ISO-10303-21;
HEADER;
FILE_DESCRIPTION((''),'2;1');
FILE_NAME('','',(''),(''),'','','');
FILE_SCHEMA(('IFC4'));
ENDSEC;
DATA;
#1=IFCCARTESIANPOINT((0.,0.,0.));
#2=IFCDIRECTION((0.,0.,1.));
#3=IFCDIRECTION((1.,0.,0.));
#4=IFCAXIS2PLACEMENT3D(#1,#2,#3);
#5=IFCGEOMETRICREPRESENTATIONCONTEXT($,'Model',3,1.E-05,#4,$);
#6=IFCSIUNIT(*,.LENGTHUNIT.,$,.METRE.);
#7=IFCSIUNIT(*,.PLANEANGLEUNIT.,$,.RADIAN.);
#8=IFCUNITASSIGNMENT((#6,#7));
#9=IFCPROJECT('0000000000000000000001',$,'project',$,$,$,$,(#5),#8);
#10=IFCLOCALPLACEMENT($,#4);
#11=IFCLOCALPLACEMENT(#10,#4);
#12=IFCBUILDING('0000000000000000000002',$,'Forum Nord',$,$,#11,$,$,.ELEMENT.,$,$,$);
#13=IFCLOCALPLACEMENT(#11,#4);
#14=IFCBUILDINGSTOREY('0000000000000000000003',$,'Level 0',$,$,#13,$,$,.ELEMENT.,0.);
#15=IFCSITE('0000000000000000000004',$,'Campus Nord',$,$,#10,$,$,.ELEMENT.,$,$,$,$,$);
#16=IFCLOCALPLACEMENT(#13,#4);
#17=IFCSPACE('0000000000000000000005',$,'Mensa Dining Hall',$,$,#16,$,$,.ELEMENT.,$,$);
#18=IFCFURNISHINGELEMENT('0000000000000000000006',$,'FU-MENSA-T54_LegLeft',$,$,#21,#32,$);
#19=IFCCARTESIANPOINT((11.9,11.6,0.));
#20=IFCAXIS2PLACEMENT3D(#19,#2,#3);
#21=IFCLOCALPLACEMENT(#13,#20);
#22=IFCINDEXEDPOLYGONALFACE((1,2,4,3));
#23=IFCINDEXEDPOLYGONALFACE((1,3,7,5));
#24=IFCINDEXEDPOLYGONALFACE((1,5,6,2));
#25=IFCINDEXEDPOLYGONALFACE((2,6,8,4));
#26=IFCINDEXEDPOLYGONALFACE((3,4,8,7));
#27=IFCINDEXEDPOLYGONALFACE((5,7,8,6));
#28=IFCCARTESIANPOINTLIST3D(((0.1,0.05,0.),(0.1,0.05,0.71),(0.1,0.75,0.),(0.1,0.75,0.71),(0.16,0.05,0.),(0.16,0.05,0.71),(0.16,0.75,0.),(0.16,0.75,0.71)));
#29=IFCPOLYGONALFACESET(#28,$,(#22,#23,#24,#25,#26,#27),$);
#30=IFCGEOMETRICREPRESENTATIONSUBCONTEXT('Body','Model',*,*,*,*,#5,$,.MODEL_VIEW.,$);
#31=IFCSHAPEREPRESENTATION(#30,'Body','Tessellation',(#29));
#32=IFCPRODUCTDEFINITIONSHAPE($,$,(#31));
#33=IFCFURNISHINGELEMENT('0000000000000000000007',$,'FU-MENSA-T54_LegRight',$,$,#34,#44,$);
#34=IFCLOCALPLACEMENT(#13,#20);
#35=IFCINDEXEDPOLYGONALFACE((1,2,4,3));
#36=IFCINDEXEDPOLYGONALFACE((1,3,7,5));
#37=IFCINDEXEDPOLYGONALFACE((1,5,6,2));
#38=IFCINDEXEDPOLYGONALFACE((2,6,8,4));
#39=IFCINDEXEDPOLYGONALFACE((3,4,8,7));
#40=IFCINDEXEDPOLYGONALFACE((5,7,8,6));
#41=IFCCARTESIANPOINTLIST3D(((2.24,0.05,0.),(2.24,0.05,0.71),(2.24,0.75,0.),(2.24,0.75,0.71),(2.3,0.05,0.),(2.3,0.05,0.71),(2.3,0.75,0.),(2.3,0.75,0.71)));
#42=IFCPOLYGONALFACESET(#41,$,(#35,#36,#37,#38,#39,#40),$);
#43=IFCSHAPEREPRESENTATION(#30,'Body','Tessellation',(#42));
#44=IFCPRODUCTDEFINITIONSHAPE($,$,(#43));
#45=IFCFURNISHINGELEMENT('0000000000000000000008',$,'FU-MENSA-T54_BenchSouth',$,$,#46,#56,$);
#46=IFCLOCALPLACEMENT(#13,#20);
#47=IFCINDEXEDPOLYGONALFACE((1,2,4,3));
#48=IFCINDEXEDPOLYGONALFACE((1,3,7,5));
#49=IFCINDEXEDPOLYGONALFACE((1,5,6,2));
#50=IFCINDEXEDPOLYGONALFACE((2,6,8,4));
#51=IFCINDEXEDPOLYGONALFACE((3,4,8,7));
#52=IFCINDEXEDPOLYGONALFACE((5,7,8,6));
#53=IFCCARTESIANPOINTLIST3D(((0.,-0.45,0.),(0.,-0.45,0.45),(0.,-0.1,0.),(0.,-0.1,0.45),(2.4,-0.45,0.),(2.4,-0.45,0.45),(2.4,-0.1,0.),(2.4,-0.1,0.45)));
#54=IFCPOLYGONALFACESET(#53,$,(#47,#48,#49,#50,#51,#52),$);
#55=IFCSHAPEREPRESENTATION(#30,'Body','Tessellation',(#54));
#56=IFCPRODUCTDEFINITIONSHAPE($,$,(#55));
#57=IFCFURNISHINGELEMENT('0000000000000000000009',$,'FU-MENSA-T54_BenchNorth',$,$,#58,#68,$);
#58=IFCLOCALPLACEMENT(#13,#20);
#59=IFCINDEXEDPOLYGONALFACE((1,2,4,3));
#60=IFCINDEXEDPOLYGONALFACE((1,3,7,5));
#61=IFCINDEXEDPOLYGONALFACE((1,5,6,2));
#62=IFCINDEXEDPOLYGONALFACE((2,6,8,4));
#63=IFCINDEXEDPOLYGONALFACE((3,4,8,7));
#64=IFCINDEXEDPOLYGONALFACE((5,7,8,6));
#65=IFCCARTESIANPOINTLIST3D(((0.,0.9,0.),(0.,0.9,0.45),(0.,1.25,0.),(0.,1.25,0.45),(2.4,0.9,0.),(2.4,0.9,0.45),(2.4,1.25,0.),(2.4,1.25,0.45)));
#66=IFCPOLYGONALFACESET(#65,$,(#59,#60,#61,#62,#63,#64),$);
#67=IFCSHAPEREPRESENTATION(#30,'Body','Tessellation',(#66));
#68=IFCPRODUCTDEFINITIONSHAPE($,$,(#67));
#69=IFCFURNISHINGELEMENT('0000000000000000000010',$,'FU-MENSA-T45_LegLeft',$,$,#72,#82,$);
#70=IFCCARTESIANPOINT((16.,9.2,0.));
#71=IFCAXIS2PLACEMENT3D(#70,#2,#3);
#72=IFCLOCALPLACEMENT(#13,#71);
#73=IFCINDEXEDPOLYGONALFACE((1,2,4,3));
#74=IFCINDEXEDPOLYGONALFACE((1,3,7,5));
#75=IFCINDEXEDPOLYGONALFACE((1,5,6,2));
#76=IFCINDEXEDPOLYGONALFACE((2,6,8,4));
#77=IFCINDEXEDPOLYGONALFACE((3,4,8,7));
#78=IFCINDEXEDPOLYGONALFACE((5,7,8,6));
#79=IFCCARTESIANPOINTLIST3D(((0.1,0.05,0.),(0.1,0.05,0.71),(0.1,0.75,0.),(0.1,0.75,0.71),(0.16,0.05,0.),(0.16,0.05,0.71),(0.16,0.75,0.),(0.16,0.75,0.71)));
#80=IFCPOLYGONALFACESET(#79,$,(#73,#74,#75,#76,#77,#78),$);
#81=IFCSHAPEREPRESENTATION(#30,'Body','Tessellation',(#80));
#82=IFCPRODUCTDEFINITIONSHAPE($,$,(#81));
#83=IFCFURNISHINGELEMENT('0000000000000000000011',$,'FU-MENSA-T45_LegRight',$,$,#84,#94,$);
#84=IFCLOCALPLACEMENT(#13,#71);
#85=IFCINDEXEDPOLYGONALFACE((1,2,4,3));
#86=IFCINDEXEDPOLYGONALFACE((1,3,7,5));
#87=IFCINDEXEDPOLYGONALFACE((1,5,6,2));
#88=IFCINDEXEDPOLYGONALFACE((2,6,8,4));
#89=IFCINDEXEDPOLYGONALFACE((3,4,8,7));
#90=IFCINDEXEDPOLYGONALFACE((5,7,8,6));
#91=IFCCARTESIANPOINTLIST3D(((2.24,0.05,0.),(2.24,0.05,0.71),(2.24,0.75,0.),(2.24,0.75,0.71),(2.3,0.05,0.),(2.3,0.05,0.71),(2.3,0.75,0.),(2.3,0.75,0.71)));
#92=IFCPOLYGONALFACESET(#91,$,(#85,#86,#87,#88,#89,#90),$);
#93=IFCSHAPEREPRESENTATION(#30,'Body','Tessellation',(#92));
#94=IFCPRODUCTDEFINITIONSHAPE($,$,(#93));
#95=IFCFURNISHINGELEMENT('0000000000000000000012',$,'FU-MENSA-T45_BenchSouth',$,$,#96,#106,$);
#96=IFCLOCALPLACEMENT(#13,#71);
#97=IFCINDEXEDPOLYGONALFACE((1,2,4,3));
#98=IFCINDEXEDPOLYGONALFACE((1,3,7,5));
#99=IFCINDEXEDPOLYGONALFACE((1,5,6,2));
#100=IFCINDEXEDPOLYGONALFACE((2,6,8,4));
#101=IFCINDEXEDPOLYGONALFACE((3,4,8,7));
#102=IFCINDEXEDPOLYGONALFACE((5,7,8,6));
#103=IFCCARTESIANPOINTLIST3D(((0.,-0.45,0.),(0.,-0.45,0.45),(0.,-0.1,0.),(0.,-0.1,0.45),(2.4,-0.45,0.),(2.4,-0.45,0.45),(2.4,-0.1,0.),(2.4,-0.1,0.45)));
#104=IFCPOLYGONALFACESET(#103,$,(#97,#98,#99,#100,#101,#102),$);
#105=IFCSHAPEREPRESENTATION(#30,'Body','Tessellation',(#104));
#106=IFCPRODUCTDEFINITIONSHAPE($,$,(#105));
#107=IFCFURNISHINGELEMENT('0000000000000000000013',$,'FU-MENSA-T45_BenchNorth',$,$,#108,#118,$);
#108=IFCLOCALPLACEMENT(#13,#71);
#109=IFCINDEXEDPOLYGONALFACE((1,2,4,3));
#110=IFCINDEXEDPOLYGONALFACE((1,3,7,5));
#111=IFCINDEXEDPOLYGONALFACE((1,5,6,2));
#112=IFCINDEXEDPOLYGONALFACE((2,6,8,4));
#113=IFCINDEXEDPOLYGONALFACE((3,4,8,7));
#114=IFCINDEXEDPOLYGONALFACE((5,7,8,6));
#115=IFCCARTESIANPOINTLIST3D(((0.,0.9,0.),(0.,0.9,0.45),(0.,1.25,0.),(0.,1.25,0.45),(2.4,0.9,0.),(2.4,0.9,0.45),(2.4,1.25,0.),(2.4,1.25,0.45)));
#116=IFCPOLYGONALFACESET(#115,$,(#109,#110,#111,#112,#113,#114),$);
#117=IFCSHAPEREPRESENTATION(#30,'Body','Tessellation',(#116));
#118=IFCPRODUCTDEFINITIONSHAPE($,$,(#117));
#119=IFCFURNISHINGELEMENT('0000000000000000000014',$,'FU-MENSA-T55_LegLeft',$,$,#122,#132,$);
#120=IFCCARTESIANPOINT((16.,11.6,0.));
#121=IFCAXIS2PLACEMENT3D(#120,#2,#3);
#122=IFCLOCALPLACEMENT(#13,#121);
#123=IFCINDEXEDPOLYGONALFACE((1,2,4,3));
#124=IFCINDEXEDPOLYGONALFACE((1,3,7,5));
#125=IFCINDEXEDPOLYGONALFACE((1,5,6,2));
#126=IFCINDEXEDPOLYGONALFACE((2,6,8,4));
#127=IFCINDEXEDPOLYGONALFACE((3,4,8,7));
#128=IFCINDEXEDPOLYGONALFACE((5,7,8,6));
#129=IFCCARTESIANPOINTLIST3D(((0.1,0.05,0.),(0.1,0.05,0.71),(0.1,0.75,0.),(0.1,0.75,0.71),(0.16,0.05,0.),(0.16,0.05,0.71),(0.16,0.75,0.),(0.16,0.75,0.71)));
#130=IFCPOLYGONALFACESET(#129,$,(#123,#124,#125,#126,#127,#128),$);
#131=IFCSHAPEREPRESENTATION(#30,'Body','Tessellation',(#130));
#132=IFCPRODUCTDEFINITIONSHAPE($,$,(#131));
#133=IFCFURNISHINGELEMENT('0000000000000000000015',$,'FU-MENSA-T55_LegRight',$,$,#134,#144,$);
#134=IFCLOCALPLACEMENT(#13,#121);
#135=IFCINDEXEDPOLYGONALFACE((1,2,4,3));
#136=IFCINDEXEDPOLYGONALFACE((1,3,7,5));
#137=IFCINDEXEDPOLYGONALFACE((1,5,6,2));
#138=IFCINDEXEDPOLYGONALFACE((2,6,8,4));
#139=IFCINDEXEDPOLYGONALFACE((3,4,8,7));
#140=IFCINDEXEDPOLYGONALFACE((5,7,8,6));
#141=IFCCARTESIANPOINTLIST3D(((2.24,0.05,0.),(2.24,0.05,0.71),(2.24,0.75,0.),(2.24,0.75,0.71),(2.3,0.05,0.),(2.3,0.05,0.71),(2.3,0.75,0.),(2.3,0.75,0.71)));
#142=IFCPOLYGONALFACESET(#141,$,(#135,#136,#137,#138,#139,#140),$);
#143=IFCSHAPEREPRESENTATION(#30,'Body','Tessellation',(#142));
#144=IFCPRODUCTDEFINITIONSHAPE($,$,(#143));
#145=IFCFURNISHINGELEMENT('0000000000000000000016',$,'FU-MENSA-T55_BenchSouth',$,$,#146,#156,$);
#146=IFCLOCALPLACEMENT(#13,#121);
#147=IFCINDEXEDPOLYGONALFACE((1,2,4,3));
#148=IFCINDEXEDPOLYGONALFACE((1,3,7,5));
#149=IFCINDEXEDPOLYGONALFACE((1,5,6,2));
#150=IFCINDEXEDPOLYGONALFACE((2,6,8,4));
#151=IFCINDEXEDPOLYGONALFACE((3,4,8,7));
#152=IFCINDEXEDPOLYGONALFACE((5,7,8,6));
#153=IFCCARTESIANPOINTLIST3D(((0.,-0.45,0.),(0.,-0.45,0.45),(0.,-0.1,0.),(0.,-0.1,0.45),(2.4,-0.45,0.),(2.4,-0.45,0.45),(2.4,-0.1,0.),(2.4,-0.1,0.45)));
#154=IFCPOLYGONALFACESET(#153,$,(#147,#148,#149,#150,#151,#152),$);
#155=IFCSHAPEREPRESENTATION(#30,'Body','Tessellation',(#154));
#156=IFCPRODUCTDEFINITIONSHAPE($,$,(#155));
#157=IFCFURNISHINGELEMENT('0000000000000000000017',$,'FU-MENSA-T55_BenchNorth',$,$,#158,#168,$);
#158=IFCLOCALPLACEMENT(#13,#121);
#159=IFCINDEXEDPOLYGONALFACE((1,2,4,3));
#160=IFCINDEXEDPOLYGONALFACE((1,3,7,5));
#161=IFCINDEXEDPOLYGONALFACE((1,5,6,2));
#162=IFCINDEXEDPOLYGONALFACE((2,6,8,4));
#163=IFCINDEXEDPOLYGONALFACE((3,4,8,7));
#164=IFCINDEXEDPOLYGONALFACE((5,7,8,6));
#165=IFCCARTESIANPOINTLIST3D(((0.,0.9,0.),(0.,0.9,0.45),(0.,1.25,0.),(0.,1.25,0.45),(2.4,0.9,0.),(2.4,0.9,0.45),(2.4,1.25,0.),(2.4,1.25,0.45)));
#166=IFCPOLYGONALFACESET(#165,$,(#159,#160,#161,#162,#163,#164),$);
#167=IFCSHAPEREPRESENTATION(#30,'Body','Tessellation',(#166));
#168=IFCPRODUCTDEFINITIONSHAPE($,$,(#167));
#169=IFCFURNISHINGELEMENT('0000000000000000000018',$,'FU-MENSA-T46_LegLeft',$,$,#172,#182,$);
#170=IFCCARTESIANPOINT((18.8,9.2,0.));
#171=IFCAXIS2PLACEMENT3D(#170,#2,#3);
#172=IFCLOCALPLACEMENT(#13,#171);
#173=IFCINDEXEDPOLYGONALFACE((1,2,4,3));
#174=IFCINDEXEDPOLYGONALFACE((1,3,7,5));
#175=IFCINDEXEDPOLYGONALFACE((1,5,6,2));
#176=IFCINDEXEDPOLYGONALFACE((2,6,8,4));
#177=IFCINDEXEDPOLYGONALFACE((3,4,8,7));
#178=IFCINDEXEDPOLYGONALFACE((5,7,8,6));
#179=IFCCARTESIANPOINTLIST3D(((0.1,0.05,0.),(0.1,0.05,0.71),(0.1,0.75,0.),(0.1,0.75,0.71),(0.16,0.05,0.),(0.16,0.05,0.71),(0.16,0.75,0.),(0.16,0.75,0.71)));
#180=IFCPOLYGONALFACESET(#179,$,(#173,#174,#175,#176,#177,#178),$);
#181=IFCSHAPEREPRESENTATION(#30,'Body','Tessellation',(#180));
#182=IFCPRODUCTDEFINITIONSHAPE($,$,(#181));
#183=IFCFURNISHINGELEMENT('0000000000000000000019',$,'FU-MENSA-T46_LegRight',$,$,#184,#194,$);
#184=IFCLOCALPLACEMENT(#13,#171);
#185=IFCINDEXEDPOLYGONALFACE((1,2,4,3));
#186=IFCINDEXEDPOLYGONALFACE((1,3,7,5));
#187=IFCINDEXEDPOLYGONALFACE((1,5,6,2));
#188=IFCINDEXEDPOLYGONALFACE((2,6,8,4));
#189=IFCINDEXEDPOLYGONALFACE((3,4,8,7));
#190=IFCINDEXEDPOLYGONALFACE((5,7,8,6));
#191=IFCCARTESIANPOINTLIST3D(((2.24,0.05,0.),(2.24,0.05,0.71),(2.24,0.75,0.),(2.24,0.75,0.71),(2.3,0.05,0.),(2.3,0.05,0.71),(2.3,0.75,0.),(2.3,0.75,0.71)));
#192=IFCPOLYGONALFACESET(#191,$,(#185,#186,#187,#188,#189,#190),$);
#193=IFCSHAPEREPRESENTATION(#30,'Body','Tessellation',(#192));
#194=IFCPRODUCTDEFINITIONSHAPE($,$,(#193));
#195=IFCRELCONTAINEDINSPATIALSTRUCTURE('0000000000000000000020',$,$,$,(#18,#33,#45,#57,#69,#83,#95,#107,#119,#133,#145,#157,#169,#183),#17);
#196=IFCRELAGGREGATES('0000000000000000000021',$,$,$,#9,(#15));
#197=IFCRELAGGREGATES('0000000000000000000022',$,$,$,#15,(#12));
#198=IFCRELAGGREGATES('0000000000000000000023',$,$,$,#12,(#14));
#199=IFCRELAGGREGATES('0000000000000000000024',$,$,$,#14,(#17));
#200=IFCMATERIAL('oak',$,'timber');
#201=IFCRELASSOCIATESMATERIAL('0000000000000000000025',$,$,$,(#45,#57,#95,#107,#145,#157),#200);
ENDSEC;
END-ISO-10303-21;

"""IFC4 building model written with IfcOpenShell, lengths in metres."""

from ifc_helpers import new_model, si_unit, frame, frame_2d, origin_with_axes, place, context, subcontext, project, spatial, rectangle, extrude, material, element, save


model = new_model("IFC4")

# Units and contexts
model_context = context("Model", 3, precision=1e-05, world=origin_with_axes())
body_context = subcontext(model_context, "Body", "Model", "MODEL_VIEW")
ifc_project = project(units=[si_unit("LENGTHUNIT", "METRE"), si_unit("PLANEANGLEUNIT", "RADIAN")], contexts=[model_context])

# Site, building, storey
site_placement = place(None, origin_with_axes())
site = spatial("IfcSite", under=ifc_project, at=site_placement, Name="Campus Nord", CompositionType="ELEMENT")
building_placement = place(site_placement, origin_with_axes())
building = spatial("IfcBuilding", under=site, at=building_placement, Name="Forum Nord", CompositionType="ELEMENT")
storey_placement = place(building_placement, origin_with_axes())
storey = spatial("IfcBuildingStorey", under=building, at=storey_placement, Name="Level 0", CompositionType="ELEMENT", Elevation=0.0)

# Shared definitions
space_placement = place(storey_placement, origin_with_axes())
space = spatial("IfcSpace", under=storey, at=space_placement, Name="Mensa Dining Hall", CompositionType="ELEMENT")

# Furnishing elements
ifc_material_1 = material(Name="oak", Category="timber")
furnishing_1_placement = place(storey_placement, frame((11.9, 11.6, 0.0), z_axis=(0.0, 0.0, 1.0), x_axis=(1.0, 0.0, 0.0)))
element("IfcFurnishingElement", 1, at=furnishing_1_placement, inside=space, Name="FU-MENSA-T54_LegLeft", context=body_context, shape_type="SweptSolid", body=[
    extrude(rectangle(XDim=0.06, YDim=0.7, at=frame_2d((0.13, 0.4), x_axis=(1.0, 0.0))), origin_with_axes(), (0.0, 0.0, 1.0), 0.71),
])
furnishing_2_placement = place(storey_placement, frame((11.9, 11.6, 0.0), z_axis=(0.0, 0.0, 1.0), x_axis=(1.0, 0.0, 0.0)))
element("IfcFurnishingElement", 2, at=furnishing_2_placement, inside=space, Name="FU-MENSA-T54_LegRight", context=body_context, shape_type="SweptSolid", body=[
    extrude(rectangle(XDim=0.06, YDim=0.7, at=frame_2d((2.27, 0.4), x_axis=(1.0, 0.0))), origin_with_axes(), (0.0, 0.0, 1.0), 0.71),
])
furnishing_3_placement = place(storey_placement, frame((11.9, 11.6, 0.0), z_axis=(0.0, 0.0, 1.0), x_axis=(1.0, 0.0, 0.0)))
element("IfcFurnishingElement", 3, at=furnishing_3_placement, inside=space, material=ifc_material_1, Name="FU-MENSA-T54_BenchSouth", context=body_context, shape_type="SweptSolid", body=[
    extrude(rectangle(XDim=2.4, YDim=0.35, at=frame_2d((1.2, -0.275), x_axis=(1.0, 0.0))), origin_with_axes(), (0.0, 0.0, 1.0), 0.45),
])
furnishing_4_placement = place(storey_placement, frame((11.9, 11.6, 0.0), z_axis=(0.0, 0.0, 1.0), x_axis=(1.0, 0.0, 0.0)))
element("IfcFurnishingElement", 4, at=furnishing_4_placement, inside=space, material=ifc_material_1, Name="FU-MENSA-T54_BenchNorth", context=body_context, shape_type="SweptSolid", body=[
    extrude(rectangle(XDim=2.4, YDim=0.35, at=frame_2d((1.2, 1.075), x_axis=(1.0, 0.0))), origin_with_axes(), (0.0, 0.0, 1.0), 0.45),
])
furnishing_5_placement = place(storey_placement, frame((16.0, 9.2, 0.0), z_axis=(0.0, 0.0, 1.0), x_axis=(1.0, 0.0, 0.0)))
element("IfcFurnishingElement", 5, at=furnishing_5_placement, inside=space, Name="FU-MENSA-T45_LegLeft", context=body_context, shape_type="SweptSolid", body=[
    extrude(rectangle(XDim=0.06, YDim=0.7, at=frame_2d((0.13, 0.4), x_axis=(1.0, 0.0))), origin_with_axes(), (0.0, 0.0, 1.0), 0.71),
])
furnishing_6_placement = place(storey_placement, frame((16.0, 9.2, 0.0), z_axis=(0.0, 0.0, 1.0), x_axis=(1.0, 0.0, 0.0)))
element("IfcFurnishingElement", 6, at=furnishing_6_placement, inside=space, Name="FU-MENSA-T45_LegRight", context=body_context, shape_type="SweptSolid", body=[
    extrude(rectangle(XDim=0.06, YDim=0.7, at=frame_2d((2.27, 0.4), x_axis=(1.0, 0.0))), origin_with_axes(), (0.0, 0.0, 1.0), 0.71),
])
furnishing_7_placement = place(storey_placement, frame((16.0, 9.2, 0.0), z_axis=(0.0, 0.0, 1.0), x_axis=(1.0, 0.0, 0.0)))
element("IfcFurnishingElement", 7, at=furnishing_7_placement, inside=space, material=ifc_material_1, Name="FU-MENSA-T45_BenchSouth", context=body_context, shape_type="SweptSolid", body=[
    extrude(rectangle(XDim=2.4, YDim=0.35, at=frame_2d((1.2, -0.275), x_axis=(1.0, 0.0))), origin_with_axes(), (0.0, 0.0, 1.0), 0.45),
])
furnishing_8_placement = place(storey_placement, frame((16.0, 9.2, 0.0), z_axis=(0.0, 0.0, 1.0), x_axis=(1.0, 0.0, 0.0)))
element("IfcFurnishingElement", 8, at=furnishing_8_placement, inside=space, material=ifc_material_1, Name="FU-MENSA-T45_BenchNorth", context=body_context, shape_type="SweptSolid", body=[
    extrude(rectangle(XDim=2.4, YDim=0.35, at=frame_2d((1.2, 1.075), x_axis=(1.0, 0.0))), origin_with_axes(), (0.0, 0.0, 1.0), 0.45),
])
furnishing_9_placement = place(storey_placement, frame((16.0, 11.6, 0.0), z_axis=(0.0, 0.0, 1.0), x_axis=(1.0, 0.0, 0.0)))
element("IfcFurnishingElement", 9, at=furnishing_9_placement, inside=space, Name="FU-MENSA-T55_LegLeft", context=body_context, shape_type="SweptSolid", body=[
    extrude(rectangle(XDim=0.06, YDim=0.7, at=frame_2d((0.13, 0.4), x_axis=(1.0, 0.0))), origin_with_axes(), (0.0, 0.0, 1.0), 0.71),
])
furnishing_10_placement = place(storey_placement, frame((16.0, 11.6, 0.0), z_axis=(0.0, 0.0, 1.0), x_axis=(1.0, 0.0, 0.0)))
element("IfcFurnishingElement", 10, at=furnishing_10_placement, inside=space, Name="FU-MENSA-T55_LegRight", context=body_context, shape_type="SweptSolid", body=[
    extrude(rectangle(XDim=0.06, YDim=0.7, at=frame_2d((2.27, 0.4), x_axis=(1.0, 0.0))), origin_with_axes(), (0.0, 0.0, 1.0), 0.71),
])
furnishing_11_placement = place(storey_placement, frame((16.0, 11.6, 0.0), z_axis=(0.0, 0.0, 1.0), x_axis=(1.0, 0.0, 0.0)))
element("IfcFurnishingElement", 11, at=furnishing_11_placement, inside=space, material=ifc_material_1, Name="FU-MENSA-T55_BenchSouth", context=body_context, shape_type="SweptSolid", body=[
    extrude(rectangle(XDim=2.4, YDim=0.35, at=frame_2d((1.2, -0.275), x_axis=(1.0, 0.0))), origin_with_axes(), (0.0, 0.0, 1.0), 0.45),
])
furnishing_12_placement = place(storey_placement, frame((16.0, 11.6, 0.0), z_axis=(0.0, 0.0, 1.0), x_axis=(1.0, 0.0, 0.0)))
element("IfcFurnishingElement", 12, at=furnishing_12_placement, inside=space, material=ifc_material_1, Name="FU-MENSA-T55_BenchNorth", context=body_context, shape_type="SweptSolid", body=[
    extrude(rectangle(XDim=2.4, YDim=0.35, at=frame_2d((1.2, 1.075), x_axis=(1.0, 0.0))), origin_with_axes(), (0.0, 0.0, 1.0), 0.45),
])
furnishing_13_placement = place(storey_placement, frame((18.8, 9.2, 0.0), z_axis=(0.0, 0.0, 1.0), x_axis=(1.0, 0.0, 0.0)))
element("IfcFurnishingElement", 13, at=furnishing_13_placement, inside=space, Name="FU-MENSA-T46_LegLeft", context=body_context, shape_type="SweptSolid", body=[
    extrude(rectangle(XDim=0.06, YDim=0.7, at=frame_2d((0.13, 0.4), x_axis=(1.0, 0.0))), origin_with_axes(), (0.0, 0.0, 1.0), 0.71),
])
furnishing_14_placement = place(storey_placement, frame((18.8, 9.2, 0.0), z_axis=(0.0, 0.0, 1.0), x_axis=(1.0, 0.0, 0.0)))
element("IfcFurnishingElement", 14, at=furnishing_14_placement, inside=space, Name="FU-MENSA-T46_LegRight", context=body_context, shape_type="SweptSolid", body=[
    extrude(rectangle(XDim=0.06, YDim=0.7, at=frame_2d((2.27, 0.4), x_axis=(1.0, 0.0))), origin_with_axes(), (0.0, 0.0, 1.0), 0.71),
])

save(model, "model.ifc")
